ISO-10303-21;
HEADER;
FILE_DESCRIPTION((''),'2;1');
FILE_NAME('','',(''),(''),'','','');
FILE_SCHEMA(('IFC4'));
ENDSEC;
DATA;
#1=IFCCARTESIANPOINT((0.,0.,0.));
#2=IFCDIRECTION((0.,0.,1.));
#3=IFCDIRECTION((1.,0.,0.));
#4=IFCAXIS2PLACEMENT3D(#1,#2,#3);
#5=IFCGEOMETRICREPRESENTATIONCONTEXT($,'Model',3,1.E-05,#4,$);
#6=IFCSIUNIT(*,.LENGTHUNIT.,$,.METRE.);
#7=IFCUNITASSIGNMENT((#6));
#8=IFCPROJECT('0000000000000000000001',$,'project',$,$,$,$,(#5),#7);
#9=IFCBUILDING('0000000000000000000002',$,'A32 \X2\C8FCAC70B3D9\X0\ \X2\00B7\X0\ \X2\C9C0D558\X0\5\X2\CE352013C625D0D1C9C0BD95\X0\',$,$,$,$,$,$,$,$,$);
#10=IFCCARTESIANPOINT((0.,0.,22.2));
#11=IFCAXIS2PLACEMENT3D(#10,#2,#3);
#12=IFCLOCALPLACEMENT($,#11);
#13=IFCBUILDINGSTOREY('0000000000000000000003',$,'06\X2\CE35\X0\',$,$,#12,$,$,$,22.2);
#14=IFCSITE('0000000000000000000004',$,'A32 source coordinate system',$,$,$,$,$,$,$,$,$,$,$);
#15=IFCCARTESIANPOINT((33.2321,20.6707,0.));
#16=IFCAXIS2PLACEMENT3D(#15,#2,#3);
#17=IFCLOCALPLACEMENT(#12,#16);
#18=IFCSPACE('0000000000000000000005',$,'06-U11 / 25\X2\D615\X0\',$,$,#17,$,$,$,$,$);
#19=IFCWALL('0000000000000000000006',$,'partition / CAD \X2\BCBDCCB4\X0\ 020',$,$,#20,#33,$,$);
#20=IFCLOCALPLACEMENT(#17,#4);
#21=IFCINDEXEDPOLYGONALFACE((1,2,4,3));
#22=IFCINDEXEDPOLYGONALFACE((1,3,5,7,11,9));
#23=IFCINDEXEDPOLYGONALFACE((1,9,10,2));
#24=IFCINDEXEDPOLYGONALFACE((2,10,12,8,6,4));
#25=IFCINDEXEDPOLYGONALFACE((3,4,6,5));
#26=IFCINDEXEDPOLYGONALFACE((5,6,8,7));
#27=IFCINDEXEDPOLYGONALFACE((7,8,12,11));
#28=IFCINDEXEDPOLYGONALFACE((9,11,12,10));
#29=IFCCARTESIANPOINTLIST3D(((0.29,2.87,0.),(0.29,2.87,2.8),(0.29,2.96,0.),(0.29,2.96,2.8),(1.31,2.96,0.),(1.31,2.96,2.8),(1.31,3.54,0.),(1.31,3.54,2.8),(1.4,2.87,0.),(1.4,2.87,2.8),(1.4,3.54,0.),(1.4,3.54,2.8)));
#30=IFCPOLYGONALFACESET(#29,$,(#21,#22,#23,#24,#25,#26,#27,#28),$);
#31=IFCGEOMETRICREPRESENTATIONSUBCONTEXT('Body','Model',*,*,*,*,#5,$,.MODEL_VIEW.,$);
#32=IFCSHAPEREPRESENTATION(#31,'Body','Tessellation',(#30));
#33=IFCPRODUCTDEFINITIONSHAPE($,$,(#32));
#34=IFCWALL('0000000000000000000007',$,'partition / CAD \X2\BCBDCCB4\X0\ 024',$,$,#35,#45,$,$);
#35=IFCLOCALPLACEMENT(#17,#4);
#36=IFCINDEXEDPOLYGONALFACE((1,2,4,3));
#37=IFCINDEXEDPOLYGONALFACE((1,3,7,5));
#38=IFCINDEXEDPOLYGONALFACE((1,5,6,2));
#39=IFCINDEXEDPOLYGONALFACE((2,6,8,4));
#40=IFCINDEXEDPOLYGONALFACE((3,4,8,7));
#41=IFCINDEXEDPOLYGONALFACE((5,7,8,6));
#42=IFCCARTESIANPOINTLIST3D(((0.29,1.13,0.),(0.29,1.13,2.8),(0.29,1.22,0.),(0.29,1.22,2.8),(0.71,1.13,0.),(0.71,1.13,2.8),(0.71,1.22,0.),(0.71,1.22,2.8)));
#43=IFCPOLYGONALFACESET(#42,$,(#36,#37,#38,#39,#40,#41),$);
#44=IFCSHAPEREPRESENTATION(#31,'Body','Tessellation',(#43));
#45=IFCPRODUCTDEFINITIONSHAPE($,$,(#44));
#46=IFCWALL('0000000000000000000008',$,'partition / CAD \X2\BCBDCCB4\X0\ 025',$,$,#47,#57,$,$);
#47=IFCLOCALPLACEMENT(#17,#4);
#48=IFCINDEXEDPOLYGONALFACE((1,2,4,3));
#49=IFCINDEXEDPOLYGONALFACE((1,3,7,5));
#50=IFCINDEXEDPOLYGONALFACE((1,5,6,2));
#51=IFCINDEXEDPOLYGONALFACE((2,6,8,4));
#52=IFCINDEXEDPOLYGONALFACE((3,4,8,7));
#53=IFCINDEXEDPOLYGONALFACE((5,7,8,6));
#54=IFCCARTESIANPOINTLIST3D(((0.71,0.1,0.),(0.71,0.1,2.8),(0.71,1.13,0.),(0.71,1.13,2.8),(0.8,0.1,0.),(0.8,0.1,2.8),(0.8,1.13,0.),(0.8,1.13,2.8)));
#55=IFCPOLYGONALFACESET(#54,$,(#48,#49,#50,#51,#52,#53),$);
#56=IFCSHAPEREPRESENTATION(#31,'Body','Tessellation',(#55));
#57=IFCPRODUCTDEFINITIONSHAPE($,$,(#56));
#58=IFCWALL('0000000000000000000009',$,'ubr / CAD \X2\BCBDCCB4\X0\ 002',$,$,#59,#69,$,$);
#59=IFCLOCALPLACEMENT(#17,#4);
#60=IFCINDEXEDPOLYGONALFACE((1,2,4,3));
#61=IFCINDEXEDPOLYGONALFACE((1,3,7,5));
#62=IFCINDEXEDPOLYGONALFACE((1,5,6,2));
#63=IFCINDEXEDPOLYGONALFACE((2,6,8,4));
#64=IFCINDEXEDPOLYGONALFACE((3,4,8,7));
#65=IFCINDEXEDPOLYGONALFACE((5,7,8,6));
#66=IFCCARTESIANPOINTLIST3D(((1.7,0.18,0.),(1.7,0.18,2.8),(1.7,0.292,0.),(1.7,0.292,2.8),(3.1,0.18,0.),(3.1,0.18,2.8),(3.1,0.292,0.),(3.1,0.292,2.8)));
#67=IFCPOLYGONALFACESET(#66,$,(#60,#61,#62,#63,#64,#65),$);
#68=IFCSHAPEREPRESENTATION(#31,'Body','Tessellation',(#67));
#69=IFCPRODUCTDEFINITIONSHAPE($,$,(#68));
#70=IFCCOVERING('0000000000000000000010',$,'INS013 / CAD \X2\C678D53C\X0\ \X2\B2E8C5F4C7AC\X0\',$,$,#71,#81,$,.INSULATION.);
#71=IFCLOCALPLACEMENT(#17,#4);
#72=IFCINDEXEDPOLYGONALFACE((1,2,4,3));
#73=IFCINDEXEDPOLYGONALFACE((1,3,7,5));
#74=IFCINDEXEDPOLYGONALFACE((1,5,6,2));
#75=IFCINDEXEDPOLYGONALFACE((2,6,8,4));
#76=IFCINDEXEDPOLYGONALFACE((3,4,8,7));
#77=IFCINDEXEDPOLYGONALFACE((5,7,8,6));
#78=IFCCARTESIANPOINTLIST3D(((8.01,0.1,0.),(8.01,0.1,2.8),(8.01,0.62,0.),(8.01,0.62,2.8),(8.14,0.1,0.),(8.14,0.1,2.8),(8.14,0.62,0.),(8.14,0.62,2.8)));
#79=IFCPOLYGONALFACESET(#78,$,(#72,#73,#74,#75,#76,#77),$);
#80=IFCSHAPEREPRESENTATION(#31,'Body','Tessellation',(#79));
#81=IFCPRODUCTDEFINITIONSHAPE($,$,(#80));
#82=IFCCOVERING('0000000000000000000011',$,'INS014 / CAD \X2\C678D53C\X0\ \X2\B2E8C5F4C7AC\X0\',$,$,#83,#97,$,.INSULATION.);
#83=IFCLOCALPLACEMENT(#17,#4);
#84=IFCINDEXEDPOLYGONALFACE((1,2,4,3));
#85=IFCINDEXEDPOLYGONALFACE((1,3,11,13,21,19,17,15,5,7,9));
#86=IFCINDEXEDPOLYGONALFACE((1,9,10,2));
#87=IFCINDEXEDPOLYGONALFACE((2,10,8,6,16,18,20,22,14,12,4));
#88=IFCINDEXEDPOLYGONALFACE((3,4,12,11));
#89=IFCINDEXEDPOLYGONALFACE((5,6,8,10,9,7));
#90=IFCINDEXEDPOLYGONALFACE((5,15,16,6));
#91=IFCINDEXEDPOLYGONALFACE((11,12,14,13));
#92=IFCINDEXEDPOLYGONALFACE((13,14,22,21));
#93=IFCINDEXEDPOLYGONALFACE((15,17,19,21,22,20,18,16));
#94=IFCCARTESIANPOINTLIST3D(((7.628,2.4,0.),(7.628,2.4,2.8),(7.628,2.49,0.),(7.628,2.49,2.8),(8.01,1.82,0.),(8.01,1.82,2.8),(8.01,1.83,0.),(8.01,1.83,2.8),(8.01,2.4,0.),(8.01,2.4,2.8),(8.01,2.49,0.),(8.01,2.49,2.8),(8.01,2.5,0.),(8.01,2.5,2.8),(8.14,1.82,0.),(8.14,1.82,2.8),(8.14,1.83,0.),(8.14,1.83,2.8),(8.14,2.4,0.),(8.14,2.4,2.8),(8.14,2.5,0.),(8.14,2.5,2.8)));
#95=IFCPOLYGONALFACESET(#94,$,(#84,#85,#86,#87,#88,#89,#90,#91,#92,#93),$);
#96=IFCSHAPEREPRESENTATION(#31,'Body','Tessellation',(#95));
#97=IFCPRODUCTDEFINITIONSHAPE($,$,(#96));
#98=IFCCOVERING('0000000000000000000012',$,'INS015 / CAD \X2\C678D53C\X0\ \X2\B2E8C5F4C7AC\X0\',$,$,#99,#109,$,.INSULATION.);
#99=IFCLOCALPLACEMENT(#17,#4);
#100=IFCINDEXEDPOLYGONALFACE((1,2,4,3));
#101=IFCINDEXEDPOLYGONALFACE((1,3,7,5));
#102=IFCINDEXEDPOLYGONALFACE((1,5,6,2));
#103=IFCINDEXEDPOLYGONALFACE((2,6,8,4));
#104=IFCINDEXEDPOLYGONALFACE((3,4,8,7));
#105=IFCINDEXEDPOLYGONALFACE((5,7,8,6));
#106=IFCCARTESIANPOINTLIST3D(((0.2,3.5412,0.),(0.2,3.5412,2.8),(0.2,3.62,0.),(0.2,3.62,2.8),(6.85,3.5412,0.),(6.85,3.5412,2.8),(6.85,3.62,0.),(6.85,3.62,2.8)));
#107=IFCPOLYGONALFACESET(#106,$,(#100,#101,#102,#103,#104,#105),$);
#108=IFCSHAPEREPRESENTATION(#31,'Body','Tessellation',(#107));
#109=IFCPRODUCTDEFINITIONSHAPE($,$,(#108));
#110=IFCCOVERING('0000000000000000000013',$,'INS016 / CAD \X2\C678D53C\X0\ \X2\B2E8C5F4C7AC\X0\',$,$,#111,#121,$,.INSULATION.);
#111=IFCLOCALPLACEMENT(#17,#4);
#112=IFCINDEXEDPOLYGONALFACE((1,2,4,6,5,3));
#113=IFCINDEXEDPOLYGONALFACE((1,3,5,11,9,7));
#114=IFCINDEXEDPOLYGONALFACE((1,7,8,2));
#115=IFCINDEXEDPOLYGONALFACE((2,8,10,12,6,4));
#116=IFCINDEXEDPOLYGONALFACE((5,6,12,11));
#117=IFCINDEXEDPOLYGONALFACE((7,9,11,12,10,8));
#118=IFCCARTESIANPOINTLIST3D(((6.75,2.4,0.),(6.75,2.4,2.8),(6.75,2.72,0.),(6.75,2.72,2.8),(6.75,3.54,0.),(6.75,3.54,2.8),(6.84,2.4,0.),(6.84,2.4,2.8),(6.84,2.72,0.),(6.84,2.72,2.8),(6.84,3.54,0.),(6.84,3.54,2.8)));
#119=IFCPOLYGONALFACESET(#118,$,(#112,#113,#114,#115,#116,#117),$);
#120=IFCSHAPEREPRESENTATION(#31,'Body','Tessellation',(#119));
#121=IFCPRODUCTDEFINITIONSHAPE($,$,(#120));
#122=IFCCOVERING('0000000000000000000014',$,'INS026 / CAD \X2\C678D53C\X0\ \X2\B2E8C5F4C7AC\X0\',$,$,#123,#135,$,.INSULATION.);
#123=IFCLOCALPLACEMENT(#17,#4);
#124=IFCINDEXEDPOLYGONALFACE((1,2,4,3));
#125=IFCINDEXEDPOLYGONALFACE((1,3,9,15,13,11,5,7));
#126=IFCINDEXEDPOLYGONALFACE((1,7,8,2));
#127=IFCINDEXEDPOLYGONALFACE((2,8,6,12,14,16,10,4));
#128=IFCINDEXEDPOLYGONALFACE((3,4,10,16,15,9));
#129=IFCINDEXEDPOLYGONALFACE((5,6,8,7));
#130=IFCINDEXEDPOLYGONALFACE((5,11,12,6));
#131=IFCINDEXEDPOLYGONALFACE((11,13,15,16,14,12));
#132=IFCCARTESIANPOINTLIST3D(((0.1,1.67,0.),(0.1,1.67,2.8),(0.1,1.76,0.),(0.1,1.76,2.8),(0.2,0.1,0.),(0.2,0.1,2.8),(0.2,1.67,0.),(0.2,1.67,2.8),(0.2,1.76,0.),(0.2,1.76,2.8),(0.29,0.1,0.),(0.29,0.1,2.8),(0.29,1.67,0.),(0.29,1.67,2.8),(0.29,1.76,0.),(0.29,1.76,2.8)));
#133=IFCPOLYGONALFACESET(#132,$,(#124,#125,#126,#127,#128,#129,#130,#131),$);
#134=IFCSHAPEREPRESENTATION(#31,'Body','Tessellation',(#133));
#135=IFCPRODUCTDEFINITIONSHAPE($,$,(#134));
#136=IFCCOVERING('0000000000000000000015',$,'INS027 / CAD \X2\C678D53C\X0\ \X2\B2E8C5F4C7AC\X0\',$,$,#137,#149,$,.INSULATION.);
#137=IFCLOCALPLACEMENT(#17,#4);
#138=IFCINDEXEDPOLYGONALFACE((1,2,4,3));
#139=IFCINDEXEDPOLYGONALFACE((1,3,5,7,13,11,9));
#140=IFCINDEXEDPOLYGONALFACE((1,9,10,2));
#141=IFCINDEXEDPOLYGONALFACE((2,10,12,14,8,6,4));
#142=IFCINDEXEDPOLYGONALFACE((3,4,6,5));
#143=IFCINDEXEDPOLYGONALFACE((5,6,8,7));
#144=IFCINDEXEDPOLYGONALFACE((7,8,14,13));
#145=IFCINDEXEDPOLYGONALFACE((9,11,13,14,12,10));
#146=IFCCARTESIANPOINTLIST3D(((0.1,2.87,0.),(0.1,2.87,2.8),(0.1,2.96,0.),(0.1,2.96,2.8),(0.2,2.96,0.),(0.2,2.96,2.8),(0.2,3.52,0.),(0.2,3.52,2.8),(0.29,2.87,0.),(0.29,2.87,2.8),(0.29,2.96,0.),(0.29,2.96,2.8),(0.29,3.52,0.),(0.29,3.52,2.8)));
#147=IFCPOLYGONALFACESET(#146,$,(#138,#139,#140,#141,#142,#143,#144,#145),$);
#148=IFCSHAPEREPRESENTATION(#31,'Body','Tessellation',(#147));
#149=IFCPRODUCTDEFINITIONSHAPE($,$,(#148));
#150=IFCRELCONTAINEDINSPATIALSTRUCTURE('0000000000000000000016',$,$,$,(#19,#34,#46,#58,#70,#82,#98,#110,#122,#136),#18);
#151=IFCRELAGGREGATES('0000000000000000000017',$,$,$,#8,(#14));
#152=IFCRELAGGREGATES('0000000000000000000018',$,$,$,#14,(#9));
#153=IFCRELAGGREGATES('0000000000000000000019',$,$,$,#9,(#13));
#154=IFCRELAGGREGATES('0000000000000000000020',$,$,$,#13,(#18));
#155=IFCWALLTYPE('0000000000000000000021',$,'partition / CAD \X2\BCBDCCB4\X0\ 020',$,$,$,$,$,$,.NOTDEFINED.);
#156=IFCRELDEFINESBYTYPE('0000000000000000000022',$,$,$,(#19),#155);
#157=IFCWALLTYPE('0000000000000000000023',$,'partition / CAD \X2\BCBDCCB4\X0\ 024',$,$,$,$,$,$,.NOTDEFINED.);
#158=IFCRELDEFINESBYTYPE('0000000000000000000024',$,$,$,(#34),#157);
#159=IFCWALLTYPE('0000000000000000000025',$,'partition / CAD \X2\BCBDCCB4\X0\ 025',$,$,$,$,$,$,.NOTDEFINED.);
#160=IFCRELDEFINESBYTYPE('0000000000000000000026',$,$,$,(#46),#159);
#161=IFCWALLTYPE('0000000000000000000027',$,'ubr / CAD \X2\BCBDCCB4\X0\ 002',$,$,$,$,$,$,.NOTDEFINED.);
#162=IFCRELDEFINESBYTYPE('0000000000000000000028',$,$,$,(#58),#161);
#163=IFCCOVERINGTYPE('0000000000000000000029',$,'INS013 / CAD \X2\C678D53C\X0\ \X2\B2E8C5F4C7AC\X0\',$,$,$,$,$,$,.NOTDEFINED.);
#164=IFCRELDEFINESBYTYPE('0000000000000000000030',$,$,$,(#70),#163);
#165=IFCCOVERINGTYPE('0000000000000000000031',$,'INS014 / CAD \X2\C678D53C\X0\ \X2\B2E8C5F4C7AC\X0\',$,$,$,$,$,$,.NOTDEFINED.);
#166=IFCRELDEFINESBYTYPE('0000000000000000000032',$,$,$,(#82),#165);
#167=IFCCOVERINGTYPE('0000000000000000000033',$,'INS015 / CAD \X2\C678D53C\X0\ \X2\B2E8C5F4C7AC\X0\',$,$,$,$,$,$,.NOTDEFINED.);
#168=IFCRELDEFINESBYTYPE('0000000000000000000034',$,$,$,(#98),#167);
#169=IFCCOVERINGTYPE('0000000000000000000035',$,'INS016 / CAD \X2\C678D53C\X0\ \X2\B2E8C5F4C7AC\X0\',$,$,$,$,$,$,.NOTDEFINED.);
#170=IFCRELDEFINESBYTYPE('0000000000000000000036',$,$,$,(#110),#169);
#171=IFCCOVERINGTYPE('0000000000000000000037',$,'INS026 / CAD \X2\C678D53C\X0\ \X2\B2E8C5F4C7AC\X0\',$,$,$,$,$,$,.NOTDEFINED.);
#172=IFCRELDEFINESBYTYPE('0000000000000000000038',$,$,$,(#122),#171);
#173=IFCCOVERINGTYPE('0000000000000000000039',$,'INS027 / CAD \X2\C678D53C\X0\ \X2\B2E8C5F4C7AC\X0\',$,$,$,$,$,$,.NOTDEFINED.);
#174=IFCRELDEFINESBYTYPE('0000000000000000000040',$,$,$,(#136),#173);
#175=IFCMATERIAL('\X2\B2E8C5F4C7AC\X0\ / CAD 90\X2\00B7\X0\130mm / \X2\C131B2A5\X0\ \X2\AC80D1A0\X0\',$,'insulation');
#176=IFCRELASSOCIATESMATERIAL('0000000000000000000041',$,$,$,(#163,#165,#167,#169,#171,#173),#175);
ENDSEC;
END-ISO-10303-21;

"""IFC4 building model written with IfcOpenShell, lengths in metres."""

from ifc_helpers import new_model, si_unit, frame, origin, origin_with_axes, place, context, subcontext, project, spatial, polyline, outline, extrude, source, transform, mapped, material, type_object, type_shapes, element, save


model = new_model("IFC4")

# Units and contexts
model_context = context("Model", 3, precision=1e-05, world=origin_with_axes())
body_context = subcontext(model_context, "Body", "Model", "MODEL_VIEW")
ifc_project = project(units=[si_unit("LENGTHUNIT", "METRE")], contexts=[model_context])

# Site, building, storey, space
storey_placement = place(None, frame((0.0, 0.0, 22.2), z_axis=(0.0, 0.0, 1.0), x_axis=(1.0, 0.0, 0.0)))
space_placement = place(storey_placement, frame((33.2321, 20.6707, 0.0), z_axis=(0.0, 0.0, 1.0), x_axis=(1.0, 0.0, 0.0)))
site = spatial("IfcSite", under=ifc_project, Name="A32 source coordinate system")
building = spatial("IfcBuilding", under=site, Name="A32 주거동 · 지하5층–옥탑지붕")
storey = spatial("IfcBuildingStorey", under=building, at=storey_placement, Name="06층", Elevation=22.2)
space = spatial("IfcSpace", under=storey, at=space_placement, Name="06-U11 / 25형")

# Walls
wall_type_1 = type_object("IfcWallType", Name="partition / CAD 벽체 020", PredefinedType="NOTDEFINED")
shared_shape_1 = source(origin(), body_context, "Body", "SweptSolid", [
    extrude(outline(polyline([(0.29, 2.87), (0.29, 2.96), (1.31, 2.96), (1.31, 3.54), (1.4, 3.54), (1.4, 2.87), (0.29, 2.87)])), origin(), (0.0, 0.0, 1.0), 2.8),
])
type_shapes(wall_type_1, [shared_shape_1])
wall_1_placement = place(space_placement, origin_with_axes())
element("IfcWall", 1, at=wall_1_placement, inside=space, type_object=wall_type_1, Name="partition / CAD 벽체 020", context=body_context, shape_type="MappedRepresentation", body=[
    mapped(shared_shape_1, transform((0.0, 0.0, 0.0), scale=1.0)),
])
wall_type_2 = type_object("IfcWallType", Name="partition / CAD 벽체 024", PredefinedType="NOTDEFINED")
shared_shape_2 = source(origin(), body_context, "Body", "SweptSolid", [
    extrude(outline(polyline([(0.71, 1.13), (0.29, 1.13), (0.29, 1.22), (0.71, 1.22), (0.71, 1.13)])), origin(), (0.0, 0.0, 1.0), 2.8),
])
type_shapes(wall_type_2, [shared_shape_2])
wall_2_placement = place(space_placement, origin_with_axes())
element("IfcWall", 2, at=wall_2_placement, inside=space, type_object=wall_type_2, Name="partition / CAD 벽체 024", context=body_context, shape_type="MappedRepresentation", body=[
    mapped(shared_shape_2, transform((0.0, 0.0, 0.0), scale=1.0)),
])
wall_type_3 = type_object("IfcWallType", Name="partition / CAD 벽체 025", PredefinedType="NOTDEFINED")
shared_shape_3 = source(origin(), body_context, "Body", "SweptSolid", [
    extrude(outline(polyline([(0.71, 1.13), (0.8, 1.13), (0.8, 0.1), (0.71, 0.1), (0.71, 1.13)])), origin(), (0.0, 0.0, 1.0), 2.8),
])
type_shapes(wall_type_3, [shared_shape_3])
wall_3_placement = place(space_placement, origin_with_axes())
element("IfcWall", 3, at=wall_3_placement, inside=space, type_object=wall_type_3, Name="partition / CAD 벽체 025", context=body_context, shape_type="MappedRepresentation", body=[
    mapped(shared_shape_3, transform((0.0, 0.0, 0.0), scale=1.0)),
])
wall_type_4 = type_object("IfcWallType", Name="ubr / CAD 벽체 002", PredefinedType="NOTDEFINED")
shared_shape_4 = source(origin(), body_context, "Body", "SweptSolid", [
    extrude(outline(polyline([(3.1, 0.292), (3.1, 0.18), (1.7, 0.18), (1.7, 0.292), (3.1, 0.292)])), origin(), (0.0, 0.0, 1.0), 2.8),
])
type_shapes(wall_type_4, [shared_shape_4])
wall_4_placement = place(space_placement, origin_with_axes())
element("IfcWall", 4, at=wall_4_placement, inside=space, type_object=wall_type_4, Name="ubr / CAD 벽체 002", context=body_context, shape_type="MappedRepresentation", body=[
    mapped(shared_shape_4, transform((0.0, 0.0, 0.0), scale=1.0)),
])

# Coverings
ifc_material = material(Name="단열재 / CAD 90·130mm / 성능 검토", Category="insulation")
covering_type_1 = type_object("IfcCoveringType", Name="INS013 / CAD 외피 단열재", PredefinedType="NOTDEFINED", material=ifc_material)
shared_shape_5 = source(origin(), body_context, "Body", "SweptSolid", [
    extrude(outline(polyline([(8.14, 0.1), (8.01, 0.1), (8.01, 0.62), (8.14, 0.62), (8.14, 0.1)])), origin(), (0.0, 0.0, 1.0), 2.8),
])
type_shapes(covering_type_1, [shared_shape_5])
covering_1_placement = place(space_placement, origin_with_axes())
element("IfcCovering", 5, at=covering_1_placement, inside=space, type_object=covering_type_1, Name="INS013 / CAD 외피 단열재", PredefinedType="INSULATION", context=body_context, shape_type="MappedRepresentation", body=[
    mapped(shared_shape_5, transform((0.0, 0.0, 0.0), scale=1.0)),
])
covering_type_2 = type_object("IfcCoveringType", Name="INS014 / CAD 외피 단열재", PredefinedType="NOTDEFINED", material=ifc_material)
shared_shape_6 = source(origin(), body_context, "Body", "SweptSolid", [
    extrude(outline(polyline([(8.14, 2.5), (8.14, 2.4), (8.14, 1.83), (8.14, 1.82), (8.01, 1.82), (8.01, 1.83), (8.01, 2.4), (7.628, 2.4), (7.628, 2.49), (8.01, 2.49), (8.01, 2.5), (8.14, 2.5)])), origin(), (0.0, 0.0, 1.0), 2.8),
])
type_shapes(covering_type_2, [shared_shape_6])
covering_2_placement = place(space_placement, origin_with_axes())
element("IfcCovering", 6, at=covering_2_placement, inside=space, type_object=covering_type_2, Name="INS014 / CAD 외피 단열재", PredefinedType="INSULATION", context=body_context, shape_type="MappedRepresentation", body=[
    mapped(shared_shape_6, transform((0.0, 0.0, 0.0), scale=1.0)),
])
covering_type_3 = type_object("IfcCoveringType", Name="INS015 / CAD 외피 단열재", PredefinedType="NOTDEFINED", material=ifc_material)
shared_shape_7 = source(origin(), body_context, "Body", "SweptSolid", [
    extrude(outline(polyline([(0.2, 3.5412), (0.2, 3.62), (6.85, 3.62), (6.85, 3.5412), (0.2, 3.5412)])), origin(), (0.0, 0.0, 1.0), 2.8),
])
type_shapes(covering_type_3, [shared_shape_7])
covering_3_placement = place(space_placement, origin_with_axes())
element("IfcCovering", 7, at=covering_3_placement, inside=space, type_object=covering_type_3, Name="INS015 / CAD 외피 단열재", PredefinedType="INSULATION", context=body_context, shape_type="MappedRepresentation", body=[
    mapped(shared_shape_7, transform((0.0, 0.0, 0.0), scale=1.0)),
])
covering_type_4 = type_object("IfcCoveringType", Name="INS016 / CAD 외피 단열재", PredefinedType="NOTDEFINED", material=ifc_material)
shared_shape_8 = source(origin(), body_context, "Body", "SweptSolid", [
    extrude(outline(polyline([(6.84, 2.72), (6.84, 2.4), (6.75, 2.4), (6.75, 2.72), (6.75, 3.54), (6.84, 3.54), (6.84, 2.72)])), origin(), (0.0, 0.0, 1.0), 2.8),
])
type_shapes(covering_type_4, [shared_shape_8])
covering_4_placement = place(space_placement, origin_with_axes())
element("IfcCovering", 8, at=covering_4_placement, inside=space, type_object=covering_type_4, Name="INS016 / CAD 외피 단열재", PredefinedType="INSULATION", context=body_context, shape_type="MappedRepresentation", body=[
    mapped(shared_shape_8, transform((0.0, 0.0, 0.0), scale=1.0)),
])
covering_type_5 = type_object("IfcCoveringType", Name="INS026 / CAD 외피 단열재", PredefinedType="NOTDEFINED", material=ifc_material)
shared_shape_9 = source(origin(), body_context, "Body", "SweptSolid", [
    extrude(outline(polyline([(0.2, 1.76), (0.29, 1.76), (0.29, 1.67), (0.29, 0.1), (0.2, 0.1), (0.2, 1.67), (0.1, 1.67), (0.1, 1.76), (0.2, 1.76)])), origin(), (0.0, 0.0, 1.0), 2.8),
])
type_shapes(covering_type_5, [shared_shape_9])
covering_5_placement = place(space_placement, origin_with_axes())
element("IfcCovering", 9, at=covering_5_placement, inside=space, type_object=covering_type_5, Name="INS026 / CAD 외피 단열재", PredefinedType="INSULATION", context=body_context, shape_type="MappedRepresentation", body=[
    mapped(shared_shape_9, transform((0.0, 0.0, 0.0), scale=1.0)),
])
covering_type_6 = type_object("IfcCoveringType", Name="INS027 / CAD 외피 단열재", PredefinedType="NOTDEFINED", material=ifc_material)
shared_shape_10 = source(origin(), body_context, "Body", "SweptSolid", [
    extrude(outline(polyline([(0.2, 3.52), (0.29, 3.52), (0.29, 2.96), (0.29, 2.87), (0.1, 2.87), (0.1, 2.96), (0.2, 2.96), (0.2, 3.52)])), origin(), (0.0, 0.0, 1.0), 2.8),
])
type_shapes(covering_type_6, [shared_shape_10])
covering_6_placement = place(space_placement, origin_with_axes())
element("IfcCovering", 10, at=covering_6_placement, inside=space, type_object=covering_type_6, Name="INS027 / CAD 외피 단열재", PredefinedType="INSULATION", context=body_context, shape_type="MappedRepresentation", body=[
    mapped(shared_shape_10, transform((0.0, 0.0, 0.0), scale=1.0)),
])

save(model, "model.ifc")
